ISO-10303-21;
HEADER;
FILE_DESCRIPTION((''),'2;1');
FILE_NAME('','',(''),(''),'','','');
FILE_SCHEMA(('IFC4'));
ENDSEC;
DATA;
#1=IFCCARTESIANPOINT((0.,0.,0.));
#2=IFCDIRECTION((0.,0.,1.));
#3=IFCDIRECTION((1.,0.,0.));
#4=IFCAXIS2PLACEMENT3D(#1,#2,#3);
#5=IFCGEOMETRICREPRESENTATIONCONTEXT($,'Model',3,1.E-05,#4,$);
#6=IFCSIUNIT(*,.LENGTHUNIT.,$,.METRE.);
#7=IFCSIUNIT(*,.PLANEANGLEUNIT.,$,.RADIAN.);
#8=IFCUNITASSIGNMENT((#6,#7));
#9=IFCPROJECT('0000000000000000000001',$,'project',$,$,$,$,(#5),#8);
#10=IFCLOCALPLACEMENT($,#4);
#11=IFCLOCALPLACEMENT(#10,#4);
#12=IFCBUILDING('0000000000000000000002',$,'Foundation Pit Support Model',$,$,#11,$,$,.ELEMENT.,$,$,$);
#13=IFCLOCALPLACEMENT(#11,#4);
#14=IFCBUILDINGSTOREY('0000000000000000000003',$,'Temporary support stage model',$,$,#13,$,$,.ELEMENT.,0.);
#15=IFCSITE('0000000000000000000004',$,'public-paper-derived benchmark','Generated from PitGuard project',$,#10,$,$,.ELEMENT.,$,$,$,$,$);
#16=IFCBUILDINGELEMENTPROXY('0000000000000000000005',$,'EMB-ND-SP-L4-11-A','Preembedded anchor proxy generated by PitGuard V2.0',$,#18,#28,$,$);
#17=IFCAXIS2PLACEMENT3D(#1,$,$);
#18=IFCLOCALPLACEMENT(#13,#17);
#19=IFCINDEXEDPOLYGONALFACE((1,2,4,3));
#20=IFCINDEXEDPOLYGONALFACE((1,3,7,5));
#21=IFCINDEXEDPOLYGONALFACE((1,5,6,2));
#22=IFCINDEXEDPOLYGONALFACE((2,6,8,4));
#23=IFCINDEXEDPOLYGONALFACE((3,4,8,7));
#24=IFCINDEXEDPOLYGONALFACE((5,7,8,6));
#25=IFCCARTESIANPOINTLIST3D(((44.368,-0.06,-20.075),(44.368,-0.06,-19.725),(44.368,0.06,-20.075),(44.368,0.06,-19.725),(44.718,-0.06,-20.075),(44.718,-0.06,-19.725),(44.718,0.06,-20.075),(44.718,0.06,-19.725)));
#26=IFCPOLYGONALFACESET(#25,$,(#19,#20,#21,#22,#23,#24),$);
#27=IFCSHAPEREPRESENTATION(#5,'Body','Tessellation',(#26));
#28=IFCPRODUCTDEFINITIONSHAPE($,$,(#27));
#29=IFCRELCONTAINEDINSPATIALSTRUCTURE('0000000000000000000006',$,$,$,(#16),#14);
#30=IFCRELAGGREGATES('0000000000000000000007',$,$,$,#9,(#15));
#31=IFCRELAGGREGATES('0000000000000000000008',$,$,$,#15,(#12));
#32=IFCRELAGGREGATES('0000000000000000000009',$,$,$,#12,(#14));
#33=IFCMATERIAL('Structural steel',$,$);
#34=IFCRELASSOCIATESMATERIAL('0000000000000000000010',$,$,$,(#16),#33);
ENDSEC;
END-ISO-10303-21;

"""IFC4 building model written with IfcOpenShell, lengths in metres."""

from ifc_helpers import new_model, si_unit, frame, origin_with_axes, origin_2d, place, context, project, spatial, rectangle, extrude, material, element, save


model = new_model("IFC4")

# Units and contexts
model_context = context("Model", 3, precision=1e-05, world=origin_with_axes())
ifc_project = project(units=[si_unit("LENGTHUNIT", "METRE"), si_unit("PLANEANGLEUNIT", "RADIAN")], contexts=[model_context])

# Site, building, storey
site_placement = place(None, origin_with_axes())
site = spatial("IfcSite", under=ifc_project, at=site_placement, Name="public-paper-derived benchmark", Description="Generated from PitGuard project", CompositionType="ELEMENT")
building_placement = place(site_placement, origin_with_axes())
building = spatial("IfcBuilding", under=site, at=building_placement, Name="Foundation Pit Support Model", CompositionType="ELEMENT")
storey_placement = place(building_placement, origin_with_axes())
storey = spatial("IfcBuildingStorey", under=building, at=storey_placement, Name="Temporary support stage model", CompositionType="ELEMENT", Elevation=0.0)

# Shared definitions
ifc_material_1 = material(Name="Structural steel")

# Building element proxy
proxy_1_placement = place(storey_placement, frame((44.543, 0.0, -20.075), z_axis=(0.0, 0.0, 1.0), x_axis=(1.0, 0.0, 0.0)))
element("IfcBuildingElementProxy", 1, at=proxy_1_placement, inside=storey, material=ifc_material_1, Name="EMB-ND-SP-L4-11-A", Description="Preembedded anchor proxy generated by PitGuard V2.0", context=model_context, shape_type="SweptSolid", body=[
    extrude(rectangle(XDim=0.35, YDim=0.12, at=origin_2d()), origin_with_axes(), (0.0, 0.0, 1.0), 0.35),
])

save(model, "model.ifc")
